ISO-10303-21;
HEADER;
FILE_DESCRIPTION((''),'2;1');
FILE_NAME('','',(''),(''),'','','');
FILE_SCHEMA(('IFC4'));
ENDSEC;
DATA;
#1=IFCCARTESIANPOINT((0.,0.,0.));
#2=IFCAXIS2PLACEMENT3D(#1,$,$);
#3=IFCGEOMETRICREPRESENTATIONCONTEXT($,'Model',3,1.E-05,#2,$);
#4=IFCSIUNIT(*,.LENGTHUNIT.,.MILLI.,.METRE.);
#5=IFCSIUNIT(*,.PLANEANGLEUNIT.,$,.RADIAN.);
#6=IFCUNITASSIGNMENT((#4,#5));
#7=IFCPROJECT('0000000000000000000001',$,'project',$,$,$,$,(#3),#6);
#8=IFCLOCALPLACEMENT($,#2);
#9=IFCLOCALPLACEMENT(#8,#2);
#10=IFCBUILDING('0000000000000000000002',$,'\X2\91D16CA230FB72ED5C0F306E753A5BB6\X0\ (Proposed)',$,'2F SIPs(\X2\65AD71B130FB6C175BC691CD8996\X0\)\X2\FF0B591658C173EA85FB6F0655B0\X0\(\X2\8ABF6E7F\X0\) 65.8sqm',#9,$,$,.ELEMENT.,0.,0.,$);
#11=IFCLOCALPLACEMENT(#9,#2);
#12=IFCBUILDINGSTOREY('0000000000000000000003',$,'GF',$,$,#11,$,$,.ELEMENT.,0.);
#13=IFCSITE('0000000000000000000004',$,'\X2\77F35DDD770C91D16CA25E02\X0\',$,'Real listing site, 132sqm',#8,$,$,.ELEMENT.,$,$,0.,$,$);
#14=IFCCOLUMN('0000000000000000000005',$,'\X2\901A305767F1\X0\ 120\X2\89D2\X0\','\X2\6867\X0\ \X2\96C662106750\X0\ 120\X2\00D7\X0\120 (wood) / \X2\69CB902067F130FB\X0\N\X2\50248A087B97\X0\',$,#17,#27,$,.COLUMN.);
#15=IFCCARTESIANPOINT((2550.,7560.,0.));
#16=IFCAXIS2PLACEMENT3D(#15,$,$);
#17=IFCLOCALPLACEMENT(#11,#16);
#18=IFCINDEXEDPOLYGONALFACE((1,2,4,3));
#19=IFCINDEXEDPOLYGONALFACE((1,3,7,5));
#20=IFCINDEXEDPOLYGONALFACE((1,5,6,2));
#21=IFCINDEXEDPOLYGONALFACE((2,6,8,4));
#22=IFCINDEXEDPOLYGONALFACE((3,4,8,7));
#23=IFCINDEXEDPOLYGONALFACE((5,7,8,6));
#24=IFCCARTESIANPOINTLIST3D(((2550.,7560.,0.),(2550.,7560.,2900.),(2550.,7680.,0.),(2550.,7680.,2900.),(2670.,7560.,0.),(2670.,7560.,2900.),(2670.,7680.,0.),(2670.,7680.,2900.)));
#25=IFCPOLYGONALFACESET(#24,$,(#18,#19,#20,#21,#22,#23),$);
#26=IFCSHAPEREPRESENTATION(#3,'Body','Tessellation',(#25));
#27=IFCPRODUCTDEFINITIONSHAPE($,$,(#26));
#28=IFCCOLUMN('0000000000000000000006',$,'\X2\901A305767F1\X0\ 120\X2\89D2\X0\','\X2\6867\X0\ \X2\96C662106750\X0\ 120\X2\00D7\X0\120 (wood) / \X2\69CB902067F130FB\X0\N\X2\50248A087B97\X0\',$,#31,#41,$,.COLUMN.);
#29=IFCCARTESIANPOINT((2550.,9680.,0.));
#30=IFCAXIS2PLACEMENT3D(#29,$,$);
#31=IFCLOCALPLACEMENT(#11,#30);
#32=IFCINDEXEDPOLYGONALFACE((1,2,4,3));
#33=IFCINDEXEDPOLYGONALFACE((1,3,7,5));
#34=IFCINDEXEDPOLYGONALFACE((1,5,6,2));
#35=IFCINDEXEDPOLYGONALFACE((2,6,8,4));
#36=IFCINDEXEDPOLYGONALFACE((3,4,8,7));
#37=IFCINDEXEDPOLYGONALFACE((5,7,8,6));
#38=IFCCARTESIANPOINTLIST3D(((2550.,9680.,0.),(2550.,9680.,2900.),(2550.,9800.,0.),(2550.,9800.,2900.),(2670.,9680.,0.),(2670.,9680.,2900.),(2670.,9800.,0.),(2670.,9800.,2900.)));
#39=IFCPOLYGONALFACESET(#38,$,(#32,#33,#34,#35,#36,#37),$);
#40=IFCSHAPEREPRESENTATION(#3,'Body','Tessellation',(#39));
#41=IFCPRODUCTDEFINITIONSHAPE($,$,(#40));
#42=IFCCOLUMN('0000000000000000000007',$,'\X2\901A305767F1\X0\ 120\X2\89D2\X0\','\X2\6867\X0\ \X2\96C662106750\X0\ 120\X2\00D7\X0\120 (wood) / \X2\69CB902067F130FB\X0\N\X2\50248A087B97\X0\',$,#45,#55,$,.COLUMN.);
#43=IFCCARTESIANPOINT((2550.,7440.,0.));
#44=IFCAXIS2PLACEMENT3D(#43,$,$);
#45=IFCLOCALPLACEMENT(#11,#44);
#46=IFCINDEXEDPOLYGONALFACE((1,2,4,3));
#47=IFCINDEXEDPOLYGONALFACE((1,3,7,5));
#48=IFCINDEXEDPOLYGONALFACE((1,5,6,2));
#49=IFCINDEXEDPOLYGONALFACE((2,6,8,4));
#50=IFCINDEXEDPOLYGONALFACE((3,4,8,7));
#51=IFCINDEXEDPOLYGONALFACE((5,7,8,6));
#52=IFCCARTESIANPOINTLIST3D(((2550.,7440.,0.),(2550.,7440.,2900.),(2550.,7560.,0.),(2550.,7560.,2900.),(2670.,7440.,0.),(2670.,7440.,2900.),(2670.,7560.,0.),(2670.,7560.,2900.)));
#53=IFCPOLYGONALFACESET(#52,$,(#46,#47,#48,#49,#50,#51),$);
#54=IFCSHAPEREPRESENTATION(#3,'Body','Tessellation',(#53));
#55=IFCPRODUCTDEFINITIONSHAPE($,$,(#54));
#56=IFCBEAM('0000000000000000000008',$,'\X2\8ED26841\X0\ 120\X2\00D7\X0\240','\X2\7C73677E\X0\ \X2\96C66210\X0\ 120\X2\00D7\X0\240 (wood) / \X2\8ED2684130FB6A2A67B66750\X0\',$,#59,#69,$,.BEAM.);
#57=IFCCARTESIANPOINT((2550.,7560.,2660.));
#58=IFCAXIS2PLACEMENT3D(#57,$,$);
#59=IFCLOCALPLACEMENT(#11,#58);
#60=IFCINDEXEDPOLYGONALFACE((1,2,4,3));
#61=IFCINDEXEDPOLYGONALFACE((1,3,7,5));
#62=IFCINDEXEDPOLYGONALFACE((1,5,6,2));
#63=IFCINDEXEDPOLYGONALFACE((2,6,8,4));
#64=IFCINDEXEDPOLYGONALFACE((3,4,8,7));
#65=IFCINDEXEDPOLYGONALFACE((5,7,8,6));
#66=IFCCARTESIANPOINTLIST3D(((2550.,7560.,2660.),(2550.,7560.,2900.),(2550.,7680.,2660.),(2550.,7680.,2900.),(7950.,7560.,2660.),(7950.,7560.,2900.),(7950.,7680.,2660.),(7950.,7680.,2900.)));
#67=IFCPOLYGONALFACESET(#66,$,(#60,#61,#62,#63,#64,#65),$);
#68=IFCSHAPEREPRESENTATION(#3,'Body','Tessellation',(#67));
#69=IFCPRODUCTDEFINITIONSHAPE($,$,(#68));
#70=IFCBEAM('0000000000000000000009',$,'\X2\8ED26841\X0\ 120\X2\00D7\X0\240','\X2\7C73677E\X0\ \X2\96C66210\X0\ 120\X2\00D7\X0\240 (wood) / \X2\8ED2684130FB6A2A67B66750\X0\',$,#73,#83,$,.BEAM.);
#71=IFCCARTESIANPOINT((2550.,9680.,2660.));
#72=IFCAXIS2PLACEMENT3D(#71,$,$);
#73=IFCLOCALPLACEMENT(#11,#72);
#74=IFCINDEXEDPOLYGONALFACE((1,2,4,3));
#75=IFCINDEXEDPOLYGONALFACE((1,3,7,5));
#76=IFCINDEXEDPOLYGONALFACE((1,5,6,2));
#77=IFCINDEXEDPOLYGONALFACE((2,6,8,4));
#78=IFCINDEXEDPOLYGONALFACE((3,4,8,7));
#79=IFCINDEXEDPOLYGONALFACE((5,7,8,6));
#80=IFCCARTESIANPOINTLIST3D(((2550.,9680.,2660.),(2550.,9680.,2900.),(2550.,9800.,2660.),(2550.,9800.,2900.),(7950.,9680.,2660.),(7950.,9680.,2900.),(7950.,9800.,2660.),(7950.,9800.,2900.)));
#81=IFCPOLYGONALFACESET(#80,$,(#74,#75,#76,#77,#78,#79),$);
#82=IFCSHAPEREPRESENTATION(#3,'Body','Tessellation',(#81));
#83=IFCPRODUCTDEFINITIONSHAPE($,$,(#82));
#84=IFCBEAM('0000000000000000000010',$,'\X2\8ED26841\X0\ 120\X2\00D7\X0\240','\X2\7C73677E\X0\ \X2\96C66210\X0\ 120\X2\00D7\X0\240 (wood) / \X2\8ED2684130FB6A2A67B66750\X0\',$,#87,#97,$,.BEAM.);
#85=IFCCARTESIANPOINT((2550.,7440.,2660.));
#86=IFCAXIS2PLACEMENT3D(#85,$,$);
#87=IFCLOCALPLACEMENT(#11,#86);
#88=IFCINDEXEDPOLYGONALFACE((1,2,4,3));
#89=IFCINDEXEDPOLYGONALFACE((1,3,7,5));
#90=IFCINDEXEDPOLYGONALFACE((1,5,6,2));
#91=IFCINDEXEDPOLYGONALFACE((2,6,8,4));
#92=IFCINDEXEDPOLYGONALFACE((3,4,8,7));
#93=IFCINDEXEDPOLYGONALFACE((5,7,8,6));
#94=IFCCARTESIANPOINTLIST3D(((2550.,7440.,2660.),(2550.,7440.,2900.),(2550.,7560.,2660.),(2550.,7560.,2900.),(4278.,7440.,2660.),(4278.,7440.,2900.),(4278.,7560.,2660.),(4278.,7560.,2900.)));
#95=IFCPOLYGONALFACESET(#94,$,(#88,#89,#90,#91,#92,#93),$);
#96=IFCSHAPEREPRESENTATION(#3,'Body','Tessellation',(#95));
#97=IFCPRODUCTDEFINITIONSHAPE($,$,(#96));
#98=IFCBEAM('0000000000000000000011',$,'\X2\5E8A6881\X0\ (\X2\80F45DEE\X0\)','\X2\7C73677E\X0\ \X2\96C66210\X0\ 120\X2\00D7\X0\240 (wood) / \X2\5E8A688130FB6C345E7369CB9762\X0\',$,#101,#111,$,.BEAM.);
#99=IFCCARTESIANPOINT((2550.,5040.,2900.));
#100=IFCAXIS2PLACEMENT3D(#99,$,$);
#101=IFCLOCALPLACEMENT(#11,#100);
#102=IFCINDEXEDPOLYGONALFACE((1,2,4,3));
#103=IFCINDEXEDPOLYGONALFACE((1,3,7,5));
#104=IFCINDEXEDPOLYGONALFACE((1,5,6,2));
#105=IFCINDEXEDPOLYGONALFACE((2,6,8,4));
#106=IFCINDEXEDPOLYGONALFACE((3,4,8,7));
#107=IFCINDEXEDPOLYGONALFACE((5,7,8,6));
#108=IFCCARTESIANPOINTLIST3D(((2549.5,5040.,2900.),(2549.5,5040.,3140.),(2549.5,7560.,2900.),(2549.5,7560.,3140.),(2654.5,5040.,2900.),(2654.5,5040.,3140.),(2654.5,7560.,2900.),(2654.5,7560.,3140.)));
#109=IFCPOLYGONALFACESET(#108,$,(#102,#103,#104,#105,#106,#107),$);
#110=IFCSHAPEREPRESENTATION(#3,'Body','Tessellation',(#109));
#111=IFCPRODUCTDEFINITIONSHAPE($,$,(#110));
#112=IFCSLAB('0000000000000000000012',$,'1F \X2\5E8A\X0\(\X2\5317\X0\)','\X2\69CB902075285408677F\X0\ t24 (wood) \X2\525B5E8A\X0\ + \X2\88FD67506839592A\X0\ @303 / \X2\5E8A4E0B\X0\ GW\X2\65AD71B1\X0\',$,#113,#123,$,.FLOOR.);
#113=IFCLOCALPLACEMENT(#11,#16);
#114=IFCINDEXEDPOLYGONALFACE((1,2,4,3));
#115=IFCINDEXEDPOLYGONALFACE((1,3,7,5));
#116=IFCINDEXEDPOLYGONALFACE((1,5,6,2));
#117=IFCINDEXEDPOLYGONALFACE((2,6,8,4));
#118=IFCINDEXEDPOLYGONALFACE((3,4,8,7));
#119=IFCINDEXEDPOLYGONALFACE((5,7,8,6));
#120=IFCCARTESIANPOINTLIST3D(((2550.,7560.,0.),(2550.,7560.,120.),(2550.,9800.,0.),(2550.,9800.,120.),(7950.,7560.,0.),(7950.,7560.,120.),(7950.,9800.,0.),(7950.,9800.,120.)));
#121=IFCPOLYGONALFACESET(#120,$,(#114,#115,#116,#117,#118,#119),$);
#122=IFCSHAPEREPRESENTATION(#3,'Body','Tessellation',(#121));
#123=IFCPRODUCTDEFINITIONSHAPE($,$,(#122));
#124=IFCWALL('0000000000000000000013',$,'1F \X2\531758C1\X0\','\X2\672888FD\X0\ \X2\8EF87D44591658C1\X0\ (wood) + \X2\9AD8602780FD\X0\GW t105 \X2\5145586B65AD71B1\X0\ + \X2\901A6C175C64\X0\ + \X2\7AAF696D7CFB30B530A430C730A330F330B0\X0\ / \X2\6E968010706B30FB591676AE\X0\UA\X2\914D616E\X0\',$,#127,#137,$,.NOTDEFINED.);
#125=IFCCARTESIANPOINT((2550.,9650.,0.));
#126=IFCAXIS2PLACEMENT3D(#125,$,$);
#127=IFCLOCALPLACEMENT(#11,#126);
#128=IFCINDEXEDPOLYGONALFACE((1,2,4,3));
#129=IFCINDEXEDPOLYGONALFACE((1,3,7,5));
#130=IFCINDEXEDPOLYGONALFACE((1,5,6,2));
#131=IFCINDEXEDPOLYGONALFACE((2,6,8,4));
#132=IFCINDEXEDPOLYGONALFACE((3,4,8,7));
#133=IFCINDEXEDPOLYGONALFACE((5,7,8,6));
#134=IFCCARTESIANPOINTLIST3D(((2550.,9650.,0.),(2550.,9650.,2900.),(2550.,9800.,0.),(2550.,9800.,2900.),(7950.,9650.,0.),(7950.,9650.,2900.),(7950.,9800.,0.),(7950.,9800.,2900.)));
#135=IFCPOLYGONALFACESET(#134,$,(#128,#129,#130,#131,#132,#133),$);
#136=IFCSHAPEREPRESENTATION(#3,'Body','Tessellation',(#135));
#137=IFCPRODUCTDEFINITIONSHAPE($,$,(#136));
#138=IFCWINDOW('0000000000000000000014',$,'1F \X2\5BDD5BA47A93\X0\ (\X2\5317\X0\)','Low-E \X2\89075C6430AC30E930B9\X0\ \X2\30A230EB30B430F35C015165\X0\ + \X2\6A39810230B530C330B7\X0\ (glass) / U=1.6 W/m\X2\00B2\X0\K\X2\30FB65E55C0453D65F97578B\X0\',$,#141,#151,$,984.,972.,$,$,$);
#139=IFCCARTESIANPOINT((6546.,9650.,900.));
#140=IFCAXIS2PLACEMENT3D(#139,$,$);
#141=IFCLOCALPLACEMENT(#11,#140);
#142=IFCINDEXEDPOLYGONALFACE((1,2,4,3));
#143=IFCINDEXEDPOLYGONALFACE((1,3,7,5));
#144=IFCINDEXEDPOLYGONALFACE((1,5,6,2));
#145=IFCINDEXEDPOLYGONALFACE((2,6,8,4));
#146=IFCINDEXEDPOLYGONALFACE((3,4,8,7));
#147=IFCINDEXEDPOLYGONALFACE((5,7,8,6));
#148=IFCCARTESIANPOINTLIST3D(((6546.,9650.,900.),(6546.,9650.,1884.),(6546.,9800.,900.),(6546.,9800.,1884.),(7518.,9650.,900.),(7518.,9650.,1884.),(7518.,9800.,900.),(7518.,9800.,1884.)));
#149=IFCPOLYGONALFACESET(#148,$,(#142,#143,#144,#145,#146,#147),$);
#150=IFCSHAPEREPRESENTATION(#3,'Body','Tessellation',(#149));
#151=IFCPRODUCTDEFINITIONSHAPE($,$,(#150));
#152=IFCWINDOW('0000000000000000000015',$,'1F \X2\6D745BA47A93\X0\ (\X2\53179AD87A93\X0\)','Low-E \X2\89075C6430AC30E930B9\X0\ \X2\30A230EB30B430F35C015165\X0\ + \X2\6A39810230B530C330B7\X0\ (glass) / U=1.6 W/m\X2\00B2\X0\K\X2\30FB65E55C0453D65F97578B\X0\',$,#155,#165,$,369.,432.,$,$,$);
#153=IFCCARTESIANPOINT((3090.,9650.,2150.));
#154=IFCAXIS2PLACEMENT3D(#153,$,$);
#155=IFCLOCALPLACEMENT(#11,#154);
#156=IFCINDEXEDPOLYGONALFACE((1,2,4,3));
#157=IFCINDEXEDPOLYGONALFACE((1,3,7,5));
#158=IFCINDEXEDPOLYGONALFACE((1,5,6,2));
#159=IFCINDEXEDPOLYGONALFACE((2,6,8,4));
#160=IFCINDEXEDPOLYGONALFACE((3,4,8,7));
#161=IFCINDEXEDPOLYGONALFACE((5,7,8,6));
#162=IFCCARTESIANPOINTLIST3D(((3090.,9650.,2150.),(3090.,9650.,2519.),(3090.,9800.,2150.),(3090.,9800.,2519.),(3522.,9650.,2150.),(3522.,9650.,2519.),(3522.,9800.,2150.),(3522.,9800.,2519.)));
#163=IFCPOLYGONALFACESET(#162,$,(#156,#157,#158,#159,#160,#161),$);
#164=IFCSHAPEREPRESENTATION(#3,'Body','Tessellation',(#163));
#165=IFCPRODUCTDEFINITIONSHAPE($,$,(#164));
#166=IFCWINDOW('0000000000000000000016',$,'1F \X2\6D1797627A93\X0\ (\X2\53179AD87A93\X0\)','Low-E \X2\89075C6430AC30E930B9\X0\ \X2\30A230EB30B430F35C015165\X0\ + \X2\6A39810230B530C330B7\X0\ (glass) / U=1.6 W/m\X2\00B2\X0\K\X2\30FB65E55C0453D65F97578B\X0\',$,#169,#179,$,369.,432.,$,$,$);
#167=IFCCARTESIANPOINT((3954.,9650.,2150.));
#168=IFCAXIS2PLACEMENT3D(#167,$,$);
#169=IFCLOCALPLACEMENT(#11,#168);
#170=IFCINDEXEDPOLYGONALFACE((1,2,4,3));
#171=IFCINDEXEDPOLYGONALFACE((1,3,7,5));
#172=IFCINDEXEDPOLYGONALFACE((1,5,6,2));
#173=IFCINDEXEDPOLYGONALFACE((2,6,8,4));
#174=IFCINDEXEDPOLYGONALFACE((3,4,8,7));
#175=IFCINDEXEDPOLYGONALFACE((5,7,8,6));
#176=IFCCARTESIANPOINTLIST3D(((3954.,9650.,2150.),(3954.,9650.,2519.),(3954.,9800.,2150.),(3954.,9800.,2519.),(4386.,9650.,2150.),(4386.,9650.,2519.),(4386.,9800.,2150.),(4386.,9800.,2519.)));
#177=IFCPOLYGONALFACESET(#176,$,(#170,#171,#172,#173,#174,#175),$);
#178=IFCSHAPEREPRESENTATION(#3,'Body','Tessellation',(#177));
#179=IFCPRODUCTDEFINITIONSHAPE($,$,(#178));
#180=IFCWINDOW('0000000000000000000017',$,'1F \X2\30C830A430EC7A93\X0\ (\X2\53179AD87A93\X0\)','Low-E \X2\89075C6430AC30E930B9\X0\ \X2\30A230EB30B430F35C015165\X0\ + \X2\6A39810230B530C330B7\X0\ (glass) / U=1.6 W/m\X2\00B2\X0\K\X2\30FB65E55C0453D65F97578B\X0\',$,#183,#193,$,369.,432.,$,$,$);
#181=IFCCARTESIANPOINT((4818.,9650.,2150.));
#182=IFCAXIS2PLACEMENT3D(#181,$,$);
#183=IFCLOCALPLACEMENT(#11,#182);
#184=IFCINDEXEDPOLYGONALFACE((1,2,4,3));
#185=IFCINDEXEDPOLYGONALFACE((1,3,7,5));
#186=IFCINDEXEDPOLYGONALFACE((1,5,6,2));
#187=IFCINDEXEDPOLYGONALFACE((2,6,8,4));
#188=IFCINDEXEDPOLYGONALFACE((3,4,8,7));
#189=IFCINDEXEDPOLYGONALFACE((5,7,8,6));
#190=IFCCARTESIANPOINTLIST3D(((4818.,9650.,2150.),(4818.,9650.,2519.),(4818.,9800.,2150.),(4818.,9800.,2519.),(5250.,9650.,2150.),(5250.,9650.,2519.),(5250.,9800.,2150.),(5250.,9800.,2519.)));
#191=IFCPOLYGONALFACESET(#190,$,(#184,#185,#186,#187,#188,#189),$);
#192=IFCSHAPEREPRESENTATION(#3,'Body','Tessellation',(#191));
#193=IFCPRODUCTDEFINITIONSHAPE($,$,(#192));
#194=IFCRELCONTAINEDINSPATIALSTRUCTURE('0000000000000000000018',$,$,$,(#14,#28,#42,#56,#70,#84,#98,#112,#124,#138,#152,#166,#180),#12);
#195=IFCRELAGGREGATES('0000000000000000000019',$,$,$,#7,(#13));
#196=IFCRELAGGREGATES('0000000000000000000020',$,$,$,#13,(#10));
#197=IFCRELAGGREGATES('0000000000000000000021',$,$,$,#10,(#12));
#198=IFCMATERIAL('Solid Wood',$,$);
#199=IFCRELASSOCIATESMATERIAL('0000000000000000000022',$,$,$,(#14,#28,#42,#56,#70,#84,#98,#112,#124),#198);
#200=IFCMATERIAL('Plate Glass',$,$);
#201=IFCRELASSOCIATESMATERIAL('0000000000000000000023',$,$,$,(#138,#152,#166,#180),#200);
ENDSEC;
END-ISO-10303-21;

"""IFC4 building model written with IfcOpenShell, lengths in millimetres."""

from ifc_helpers import new_model, si_unit, frame, frame_2d, origin, place, context, project, spatial, rectangle, extrude, material, element, fill, save


model = new_model("IFC4")

# Units and contexts
model_context = context("Model", 3, precision=1e-05, world=origin())
ifc_project = project(units=[si_unit("LENGTHUNIT", "METRE", prefix="MILLI"), si_unit("PLANEANGLEUNIT", "RADIAN")], contexts=[model_context])

# Site, building, storey
site_placement = place(None, origin())
site = spatial("IfcSite", under=ifc_project, at=site_placement, Name="石川県金沢市", ObjectType="Real listing site, 132sqm", CompositionType="ELEMENT", RefElevation=0.0)
building_placement = place(site_placement, origin())
building = spatial("IfcBuilding", under=site, at=building_placement, Name="金沢・狭小の町家 (Proposed)", ObjectType="2F SIPs(断熱・気密重視)＋外壁珪藻漆喰(調湿) 65.8sqm", CompositionType="ELEMENT", ElevationOfRefHeight=0.0, ElevationOfTerrain=0.0)
storey_placement = place(building_placement, origin())
storey = spatial("IfcBuildingStorey", under=building, at=storey_placement, Name="GF", CompositionType="ELEMENT", Elevation=0.0)

# Columns
ifc_material_1 = material(Name="Solid Wood")
column_1_placement = place(storey_placement, frame((2550.0, 7560.0, 0.0)))
element("IfcColumn", 1, at=column_1_placement, inside=storey, material=ifc_material_1, Name="通し柱 120角", Description="桧 集成材 120×120 (wood) / 構造柱・N値計算", PredefinedType="COLUMN", context=model_context, shape_type="SweptSolid", body=[
    extrude(rectangle(XDim=120.0, YDim=120.0, at=frame_2d((60.0, 60.0))), frame((2550.0, 7560.0, 0.0)), (0.0, 0.0, 1.0), 2900.0),
])
column_2_placement = place(storey_placement, frame((2550.0, 9680.0, 0.0)))
element("IfcColumn", 2, at=column_2_placement, inside=storey, material=ifc_material_1, Name="通し柱 120角", Description="桧 集成材 120×120 (wood) / 構造柱・N値計算", PredefinedType="COLUMN", context=model_context, shape_type="SweptSolid", body=[
    extrude(rectangle(XDim=120.0, YDim=120.0, at=frame_2d((60.0, 60.0))), frame((2550.0, 9680.0, 0.0)), (0.0, 0.0, 1.0), 2900.0),
])
column_3_placement = place(storey_placement, frame((2550.0, 7440.0, 0.0)))
element("IfcColumn", 3, at=column_3_placement, inside=storey, material=ifc_material_1, Name="通し柱 120角", Description="桧 集成材 120×120 (wood) / 構造柱・N値計算", PredefinedType="COLUMN", context=model_context, shape_type="SweptSolid", body=[
    extrude(rectangle(XDim=120.0, YDim=120.0, at=frame_2d((60.0, 60.0))), frame((2550.0, 7440.0, 0.0)), (0.0, 0.0, 1.0), 2900.0),
])

# Beams
beam_1_placement = place(storey_placement, frame((2550.0, 7560.0, 2660.0)))
element("IfcBeam", 4, at=beam_1_placement, inside=storey, material=ifc_material_1, Name="軒桁 120×240", Description="米松 集成 120×240 (wood) / 軒桁・横架材", PredefinedType="BEAM", context=model_context, shape_type="SweptSolid", body=[
    extrude(rectangle(XDim=5400.0, YDim=120.0, at=frame_2d((2700.0, 60.0))), frame((2550.0, 7560.0, 2660.0)), (0.0, 0.0, 1.0), 240.0),
])
beam_2_placement = place(storey_placement, frame((2550.0, 9680.0, 2660.0)))
element("IfcBeam", 5, at=beam_2_placement, inside=storey, material=ifc_material_1, Name="軒桁 120×240", Description="米松 集成 120×240 (wood) / 軒桁・横架材", PredefinedType="BEAM", context=model_context, shape_type="SweptSolid", body=[
    extrude(rectangle(XDim=5400.0, YDim=120.0, at=frame_2d((2700.0, 60.0))), frame((2550.0, 9680.0, 2660.0)), (0.0, 0.0, 1.0), 240.0),
])
beam_3_placement = place(storey_placement, frame((2550.0, 7440.0, 2660.0)))
element("IfcBeam", 6, at=beam_3_placement, inside=storey, material=ifc_material_1, Name="軒桁 120×240", Description="米松 集成 120×240 (wood) / 軒桁・横架材", PredefinedType="BEAM", context=model_context, shape_type="SweptSolid", body=[
    extrude(rectangle(XDim=1728.0, YDim=120.0, at=frame_2d((864.0, 60.0))), frame((2550.0, 7440.0, 2660.0)), (0.0, 0.0, 1.0), 240.0),
])
beam_4_placement = place(storey_placement, frame((2550.0, 5040.0, 2900.0)))
element("IfcBeam", 7, at=beam_4_placement, inside=storey, material=ifc_material_1, Name="床梁 (胴差)", Description="米松 集成 120×240 (wood) / 床梁・水平構面", PredefinedType="BEAM", context=model_context, shape_type="SweptSolid", body=[
    extrude(rectangle(XDim=105.0, YDim=2520.0, at=frame_2d((52.0, 1260.0))), frame((2550.0, 5040.0, 2900.0)), (0.0, 0.0, 1.0), 240.0),
])

# Slab
slab_placement = place(storey_placement, frame((2550.0, 7560.0, 0.0)))
element("IfcSlab", 8, at=slab_placement, inside=storey, material=ifc_material_1, Name="1F 床(北)", Description="構造用合板 t24 (wood) 剛床 + 製材根太 @303 / 床下 GW断熱", PredefinedType="FLOOR", context=model_context, shape_type="SweptSolid", body=[
    extrude(rectangle(XDim=5400.0, YDim=2240.0, at=frame_2d((2700.0, 1120.0))), frame((2550.0, 7560.0, 0.0)), (0.0, 0.0, 1.0), 120.0),
])

# Wall, openings, windows
wall_1_placement = place(storey_placement, frame((2550.0, 9650.0, 0.0)))
wall_1 = element("IfcWall", 9, at=wall_1_placement, inside=storey, material=ifc_material_1, Name="1F 北壁", Description="木製 軸組外壁 (wood) + 高性能GW t105 充填断熱 + 通気層 + 窯業系サイディング / 準耐火・外皮UA配慮", PredefinedType="NOTDEFINED", context=model_context, shape_type="SweptSolid", body=[
    extrude(rectangle(XDim=5400.0, YDim=150.0, at=frame_2d((2700.0, 75.0))), frame((2550.0, 9650.0, 0.0)), (0.0, 0.0, 1.0), 2900.0),
])
opening_1_placement = place(storey_placement, frame((6546.0, 9650.0, 900.0)))
opening_1 = element("IfcOpeningElement", 10, at=opening_1_placement, cuts=wall_1, PredefinedType="NOTDEFINED", context=model_context, shape_type="SweptSolid", body=[
    extrude(rectangle(XDim=972.0, YDim=150.0, at=frame_2d((486.0, 75.0))), frame((6546.0, 9650.0, 900.0)), (0.0, 0.0, 1.0), 984.0),
])
opening_2_placement = place(storey_placement, frame((3090.0, 9650.0, 2150.0)))
opening_2 = element("IfcOpeningElement", 11, at=opening_2_placement, cuts=wall_1, PredefinedType="NOTDEFINED", context=model_context, shape_type="SweptSolid", body=[
    extrude(rectangle(XDim=432.0, YDim=150.0, at=frame_2d((216.0, 75.0))), frame((3090.0, 9650.0, 2150.0)), (0.0, 0.0, 1.0), 369.0),
])
opening_3_placement = place(storey_placement, frame((3954.0, 9650.0, 2150.0)))
opening_3 = element("IfcOpeningElement", 12, at=opening_3_placement, cuts=wall_1, PredefinedType="NOTDEFINED", context=model_context, shape_type="SweptSolid", body=[
    extrude(rectangle(XDim=432.0, YDim=150.0, at=frame_2d((216.0, 75.0))), frame((3954.0, 9650.0, 2150.0)), (0.0, 0.0, 1.0), 369.0),
])
opening_4_placement = place(storey_placement, frame((4818.0, 9650.0, 2150.0)))
opening_4 = element("IfcOpeningElement", 13, at=opening_4_placement, cuts=wall_1, PredefinedType="NOTDEFINED", context=model_context, shape_type="SweptSolid", body=[
    extrude(rectangle(XDim=432.0, YDim=150.0, at=frame_2d((216.0, 75.0))), frame((4818.0, 9650.0, 2150.0)), (0.0, 0.0, 1.0), 369.0),
])
ifc_material_2 = material(Name="Plate Glass")
window_1_placement = place(storey_placement, frame((6546.0, 9650.0, 900.0)))
window_1 = element("IfcWindow", 14, at=window_1_placement, inside=storey, material=ifc_material_2, Name="1F 寝室窓 (北)", Description="Low-E 複層ガラス アルゴン封入 + 樹脂サッシ (glass) / U=1.6 W/m²K・日射取得型", OverallHeight=984.0, OverallWidth=972.0, context=model_context, shape_type="SweptSolid", body=[
    extrude(rectangle(XDim=972.0, YDim=150.0, at=frame_2d((486.0, 75.0))), frame((6546.0, 9650.0, 900.0)), (0.0, 0.0, 1.0), 984.0),
])
fill(opening_1, window_1)
window_2_placement = place(storey_placement, frame((3090.0, 9650.0, 2150.0)))
window_2 = element("IfcWindow", 15, at=window_2_placement, inside=storey, material=ifc_material_2, Name="1F 浴室窓 (北高窓)", Description="Low-E 複層ガラス アルゴン封入 + 樹脂サッシ (glass) / U=1.6 W/m²K・日射取得型", OverallHeight=369.0, OverallWidth=432.0, context=model_context, shape_type="SweptSolid", body=[
    extrude(rectangle(XDim=432.0, YDim=150.0, at=frame_2d((216.0, 75.0))), frame((3090.0, 9650.0, 2150.0)), (0.0, 0.0, 1.0), 369.0),
])
fill(opening_2, window_2)
window_3_placement = place(storey_placement, frame((3954.0, 9650.0, 2150.0)))
window_3 = element("IfcWindow", 16, at=window_3_placement, inside=storey, material=ifc_material_2, Name="1F 洗面窓 (北高窓)", Description="Low-E 複層ガラス アルゴン封入 + 樹脂サッシ (glass) / U=1.6 W/m²K・日射取得型", OverallHeight=369.0, OverallWidth=432.0, context=model_context, shape_type="SweptSolid", body=[
    extrude(rectangle(XDim=432.0, YDim=150.0, at=frame_2d((216.0, 75.0))), frame((3954.0, 9650.0, 2150.0)), (0.0, 0.0, 1.0), 369.0),
])
fill(opening_3, window_3)
window_4_placement = place(storey_placement, frame((4818.0, 9650.0, 2150.0)))
window_4 = element("IfcWindow", 17, at=window_4_placement, inside=storey, material=ifc_material_2, Name="1F トイレ窓 (北高窓)", Description="Low-E 複層ガラス アルゴン封入 + 樹脂サッシ (glass) / U=1.6 W/m²K・日射取得型", OverallHeight=369.0, OverallWidth=432.0, context=model_context, shape_type="SweptSolid", body=[
    extrude(rectangle(XDim=432.0, YDim=150.0, at=frame_2d((216.0, 75.0))), frame((4818.0, 9650.0, 2150.0)), (0.0, 0.0, 1.0), 369.0),
])
fill(opening_4, window_4)

save(model, "model.ifc")
